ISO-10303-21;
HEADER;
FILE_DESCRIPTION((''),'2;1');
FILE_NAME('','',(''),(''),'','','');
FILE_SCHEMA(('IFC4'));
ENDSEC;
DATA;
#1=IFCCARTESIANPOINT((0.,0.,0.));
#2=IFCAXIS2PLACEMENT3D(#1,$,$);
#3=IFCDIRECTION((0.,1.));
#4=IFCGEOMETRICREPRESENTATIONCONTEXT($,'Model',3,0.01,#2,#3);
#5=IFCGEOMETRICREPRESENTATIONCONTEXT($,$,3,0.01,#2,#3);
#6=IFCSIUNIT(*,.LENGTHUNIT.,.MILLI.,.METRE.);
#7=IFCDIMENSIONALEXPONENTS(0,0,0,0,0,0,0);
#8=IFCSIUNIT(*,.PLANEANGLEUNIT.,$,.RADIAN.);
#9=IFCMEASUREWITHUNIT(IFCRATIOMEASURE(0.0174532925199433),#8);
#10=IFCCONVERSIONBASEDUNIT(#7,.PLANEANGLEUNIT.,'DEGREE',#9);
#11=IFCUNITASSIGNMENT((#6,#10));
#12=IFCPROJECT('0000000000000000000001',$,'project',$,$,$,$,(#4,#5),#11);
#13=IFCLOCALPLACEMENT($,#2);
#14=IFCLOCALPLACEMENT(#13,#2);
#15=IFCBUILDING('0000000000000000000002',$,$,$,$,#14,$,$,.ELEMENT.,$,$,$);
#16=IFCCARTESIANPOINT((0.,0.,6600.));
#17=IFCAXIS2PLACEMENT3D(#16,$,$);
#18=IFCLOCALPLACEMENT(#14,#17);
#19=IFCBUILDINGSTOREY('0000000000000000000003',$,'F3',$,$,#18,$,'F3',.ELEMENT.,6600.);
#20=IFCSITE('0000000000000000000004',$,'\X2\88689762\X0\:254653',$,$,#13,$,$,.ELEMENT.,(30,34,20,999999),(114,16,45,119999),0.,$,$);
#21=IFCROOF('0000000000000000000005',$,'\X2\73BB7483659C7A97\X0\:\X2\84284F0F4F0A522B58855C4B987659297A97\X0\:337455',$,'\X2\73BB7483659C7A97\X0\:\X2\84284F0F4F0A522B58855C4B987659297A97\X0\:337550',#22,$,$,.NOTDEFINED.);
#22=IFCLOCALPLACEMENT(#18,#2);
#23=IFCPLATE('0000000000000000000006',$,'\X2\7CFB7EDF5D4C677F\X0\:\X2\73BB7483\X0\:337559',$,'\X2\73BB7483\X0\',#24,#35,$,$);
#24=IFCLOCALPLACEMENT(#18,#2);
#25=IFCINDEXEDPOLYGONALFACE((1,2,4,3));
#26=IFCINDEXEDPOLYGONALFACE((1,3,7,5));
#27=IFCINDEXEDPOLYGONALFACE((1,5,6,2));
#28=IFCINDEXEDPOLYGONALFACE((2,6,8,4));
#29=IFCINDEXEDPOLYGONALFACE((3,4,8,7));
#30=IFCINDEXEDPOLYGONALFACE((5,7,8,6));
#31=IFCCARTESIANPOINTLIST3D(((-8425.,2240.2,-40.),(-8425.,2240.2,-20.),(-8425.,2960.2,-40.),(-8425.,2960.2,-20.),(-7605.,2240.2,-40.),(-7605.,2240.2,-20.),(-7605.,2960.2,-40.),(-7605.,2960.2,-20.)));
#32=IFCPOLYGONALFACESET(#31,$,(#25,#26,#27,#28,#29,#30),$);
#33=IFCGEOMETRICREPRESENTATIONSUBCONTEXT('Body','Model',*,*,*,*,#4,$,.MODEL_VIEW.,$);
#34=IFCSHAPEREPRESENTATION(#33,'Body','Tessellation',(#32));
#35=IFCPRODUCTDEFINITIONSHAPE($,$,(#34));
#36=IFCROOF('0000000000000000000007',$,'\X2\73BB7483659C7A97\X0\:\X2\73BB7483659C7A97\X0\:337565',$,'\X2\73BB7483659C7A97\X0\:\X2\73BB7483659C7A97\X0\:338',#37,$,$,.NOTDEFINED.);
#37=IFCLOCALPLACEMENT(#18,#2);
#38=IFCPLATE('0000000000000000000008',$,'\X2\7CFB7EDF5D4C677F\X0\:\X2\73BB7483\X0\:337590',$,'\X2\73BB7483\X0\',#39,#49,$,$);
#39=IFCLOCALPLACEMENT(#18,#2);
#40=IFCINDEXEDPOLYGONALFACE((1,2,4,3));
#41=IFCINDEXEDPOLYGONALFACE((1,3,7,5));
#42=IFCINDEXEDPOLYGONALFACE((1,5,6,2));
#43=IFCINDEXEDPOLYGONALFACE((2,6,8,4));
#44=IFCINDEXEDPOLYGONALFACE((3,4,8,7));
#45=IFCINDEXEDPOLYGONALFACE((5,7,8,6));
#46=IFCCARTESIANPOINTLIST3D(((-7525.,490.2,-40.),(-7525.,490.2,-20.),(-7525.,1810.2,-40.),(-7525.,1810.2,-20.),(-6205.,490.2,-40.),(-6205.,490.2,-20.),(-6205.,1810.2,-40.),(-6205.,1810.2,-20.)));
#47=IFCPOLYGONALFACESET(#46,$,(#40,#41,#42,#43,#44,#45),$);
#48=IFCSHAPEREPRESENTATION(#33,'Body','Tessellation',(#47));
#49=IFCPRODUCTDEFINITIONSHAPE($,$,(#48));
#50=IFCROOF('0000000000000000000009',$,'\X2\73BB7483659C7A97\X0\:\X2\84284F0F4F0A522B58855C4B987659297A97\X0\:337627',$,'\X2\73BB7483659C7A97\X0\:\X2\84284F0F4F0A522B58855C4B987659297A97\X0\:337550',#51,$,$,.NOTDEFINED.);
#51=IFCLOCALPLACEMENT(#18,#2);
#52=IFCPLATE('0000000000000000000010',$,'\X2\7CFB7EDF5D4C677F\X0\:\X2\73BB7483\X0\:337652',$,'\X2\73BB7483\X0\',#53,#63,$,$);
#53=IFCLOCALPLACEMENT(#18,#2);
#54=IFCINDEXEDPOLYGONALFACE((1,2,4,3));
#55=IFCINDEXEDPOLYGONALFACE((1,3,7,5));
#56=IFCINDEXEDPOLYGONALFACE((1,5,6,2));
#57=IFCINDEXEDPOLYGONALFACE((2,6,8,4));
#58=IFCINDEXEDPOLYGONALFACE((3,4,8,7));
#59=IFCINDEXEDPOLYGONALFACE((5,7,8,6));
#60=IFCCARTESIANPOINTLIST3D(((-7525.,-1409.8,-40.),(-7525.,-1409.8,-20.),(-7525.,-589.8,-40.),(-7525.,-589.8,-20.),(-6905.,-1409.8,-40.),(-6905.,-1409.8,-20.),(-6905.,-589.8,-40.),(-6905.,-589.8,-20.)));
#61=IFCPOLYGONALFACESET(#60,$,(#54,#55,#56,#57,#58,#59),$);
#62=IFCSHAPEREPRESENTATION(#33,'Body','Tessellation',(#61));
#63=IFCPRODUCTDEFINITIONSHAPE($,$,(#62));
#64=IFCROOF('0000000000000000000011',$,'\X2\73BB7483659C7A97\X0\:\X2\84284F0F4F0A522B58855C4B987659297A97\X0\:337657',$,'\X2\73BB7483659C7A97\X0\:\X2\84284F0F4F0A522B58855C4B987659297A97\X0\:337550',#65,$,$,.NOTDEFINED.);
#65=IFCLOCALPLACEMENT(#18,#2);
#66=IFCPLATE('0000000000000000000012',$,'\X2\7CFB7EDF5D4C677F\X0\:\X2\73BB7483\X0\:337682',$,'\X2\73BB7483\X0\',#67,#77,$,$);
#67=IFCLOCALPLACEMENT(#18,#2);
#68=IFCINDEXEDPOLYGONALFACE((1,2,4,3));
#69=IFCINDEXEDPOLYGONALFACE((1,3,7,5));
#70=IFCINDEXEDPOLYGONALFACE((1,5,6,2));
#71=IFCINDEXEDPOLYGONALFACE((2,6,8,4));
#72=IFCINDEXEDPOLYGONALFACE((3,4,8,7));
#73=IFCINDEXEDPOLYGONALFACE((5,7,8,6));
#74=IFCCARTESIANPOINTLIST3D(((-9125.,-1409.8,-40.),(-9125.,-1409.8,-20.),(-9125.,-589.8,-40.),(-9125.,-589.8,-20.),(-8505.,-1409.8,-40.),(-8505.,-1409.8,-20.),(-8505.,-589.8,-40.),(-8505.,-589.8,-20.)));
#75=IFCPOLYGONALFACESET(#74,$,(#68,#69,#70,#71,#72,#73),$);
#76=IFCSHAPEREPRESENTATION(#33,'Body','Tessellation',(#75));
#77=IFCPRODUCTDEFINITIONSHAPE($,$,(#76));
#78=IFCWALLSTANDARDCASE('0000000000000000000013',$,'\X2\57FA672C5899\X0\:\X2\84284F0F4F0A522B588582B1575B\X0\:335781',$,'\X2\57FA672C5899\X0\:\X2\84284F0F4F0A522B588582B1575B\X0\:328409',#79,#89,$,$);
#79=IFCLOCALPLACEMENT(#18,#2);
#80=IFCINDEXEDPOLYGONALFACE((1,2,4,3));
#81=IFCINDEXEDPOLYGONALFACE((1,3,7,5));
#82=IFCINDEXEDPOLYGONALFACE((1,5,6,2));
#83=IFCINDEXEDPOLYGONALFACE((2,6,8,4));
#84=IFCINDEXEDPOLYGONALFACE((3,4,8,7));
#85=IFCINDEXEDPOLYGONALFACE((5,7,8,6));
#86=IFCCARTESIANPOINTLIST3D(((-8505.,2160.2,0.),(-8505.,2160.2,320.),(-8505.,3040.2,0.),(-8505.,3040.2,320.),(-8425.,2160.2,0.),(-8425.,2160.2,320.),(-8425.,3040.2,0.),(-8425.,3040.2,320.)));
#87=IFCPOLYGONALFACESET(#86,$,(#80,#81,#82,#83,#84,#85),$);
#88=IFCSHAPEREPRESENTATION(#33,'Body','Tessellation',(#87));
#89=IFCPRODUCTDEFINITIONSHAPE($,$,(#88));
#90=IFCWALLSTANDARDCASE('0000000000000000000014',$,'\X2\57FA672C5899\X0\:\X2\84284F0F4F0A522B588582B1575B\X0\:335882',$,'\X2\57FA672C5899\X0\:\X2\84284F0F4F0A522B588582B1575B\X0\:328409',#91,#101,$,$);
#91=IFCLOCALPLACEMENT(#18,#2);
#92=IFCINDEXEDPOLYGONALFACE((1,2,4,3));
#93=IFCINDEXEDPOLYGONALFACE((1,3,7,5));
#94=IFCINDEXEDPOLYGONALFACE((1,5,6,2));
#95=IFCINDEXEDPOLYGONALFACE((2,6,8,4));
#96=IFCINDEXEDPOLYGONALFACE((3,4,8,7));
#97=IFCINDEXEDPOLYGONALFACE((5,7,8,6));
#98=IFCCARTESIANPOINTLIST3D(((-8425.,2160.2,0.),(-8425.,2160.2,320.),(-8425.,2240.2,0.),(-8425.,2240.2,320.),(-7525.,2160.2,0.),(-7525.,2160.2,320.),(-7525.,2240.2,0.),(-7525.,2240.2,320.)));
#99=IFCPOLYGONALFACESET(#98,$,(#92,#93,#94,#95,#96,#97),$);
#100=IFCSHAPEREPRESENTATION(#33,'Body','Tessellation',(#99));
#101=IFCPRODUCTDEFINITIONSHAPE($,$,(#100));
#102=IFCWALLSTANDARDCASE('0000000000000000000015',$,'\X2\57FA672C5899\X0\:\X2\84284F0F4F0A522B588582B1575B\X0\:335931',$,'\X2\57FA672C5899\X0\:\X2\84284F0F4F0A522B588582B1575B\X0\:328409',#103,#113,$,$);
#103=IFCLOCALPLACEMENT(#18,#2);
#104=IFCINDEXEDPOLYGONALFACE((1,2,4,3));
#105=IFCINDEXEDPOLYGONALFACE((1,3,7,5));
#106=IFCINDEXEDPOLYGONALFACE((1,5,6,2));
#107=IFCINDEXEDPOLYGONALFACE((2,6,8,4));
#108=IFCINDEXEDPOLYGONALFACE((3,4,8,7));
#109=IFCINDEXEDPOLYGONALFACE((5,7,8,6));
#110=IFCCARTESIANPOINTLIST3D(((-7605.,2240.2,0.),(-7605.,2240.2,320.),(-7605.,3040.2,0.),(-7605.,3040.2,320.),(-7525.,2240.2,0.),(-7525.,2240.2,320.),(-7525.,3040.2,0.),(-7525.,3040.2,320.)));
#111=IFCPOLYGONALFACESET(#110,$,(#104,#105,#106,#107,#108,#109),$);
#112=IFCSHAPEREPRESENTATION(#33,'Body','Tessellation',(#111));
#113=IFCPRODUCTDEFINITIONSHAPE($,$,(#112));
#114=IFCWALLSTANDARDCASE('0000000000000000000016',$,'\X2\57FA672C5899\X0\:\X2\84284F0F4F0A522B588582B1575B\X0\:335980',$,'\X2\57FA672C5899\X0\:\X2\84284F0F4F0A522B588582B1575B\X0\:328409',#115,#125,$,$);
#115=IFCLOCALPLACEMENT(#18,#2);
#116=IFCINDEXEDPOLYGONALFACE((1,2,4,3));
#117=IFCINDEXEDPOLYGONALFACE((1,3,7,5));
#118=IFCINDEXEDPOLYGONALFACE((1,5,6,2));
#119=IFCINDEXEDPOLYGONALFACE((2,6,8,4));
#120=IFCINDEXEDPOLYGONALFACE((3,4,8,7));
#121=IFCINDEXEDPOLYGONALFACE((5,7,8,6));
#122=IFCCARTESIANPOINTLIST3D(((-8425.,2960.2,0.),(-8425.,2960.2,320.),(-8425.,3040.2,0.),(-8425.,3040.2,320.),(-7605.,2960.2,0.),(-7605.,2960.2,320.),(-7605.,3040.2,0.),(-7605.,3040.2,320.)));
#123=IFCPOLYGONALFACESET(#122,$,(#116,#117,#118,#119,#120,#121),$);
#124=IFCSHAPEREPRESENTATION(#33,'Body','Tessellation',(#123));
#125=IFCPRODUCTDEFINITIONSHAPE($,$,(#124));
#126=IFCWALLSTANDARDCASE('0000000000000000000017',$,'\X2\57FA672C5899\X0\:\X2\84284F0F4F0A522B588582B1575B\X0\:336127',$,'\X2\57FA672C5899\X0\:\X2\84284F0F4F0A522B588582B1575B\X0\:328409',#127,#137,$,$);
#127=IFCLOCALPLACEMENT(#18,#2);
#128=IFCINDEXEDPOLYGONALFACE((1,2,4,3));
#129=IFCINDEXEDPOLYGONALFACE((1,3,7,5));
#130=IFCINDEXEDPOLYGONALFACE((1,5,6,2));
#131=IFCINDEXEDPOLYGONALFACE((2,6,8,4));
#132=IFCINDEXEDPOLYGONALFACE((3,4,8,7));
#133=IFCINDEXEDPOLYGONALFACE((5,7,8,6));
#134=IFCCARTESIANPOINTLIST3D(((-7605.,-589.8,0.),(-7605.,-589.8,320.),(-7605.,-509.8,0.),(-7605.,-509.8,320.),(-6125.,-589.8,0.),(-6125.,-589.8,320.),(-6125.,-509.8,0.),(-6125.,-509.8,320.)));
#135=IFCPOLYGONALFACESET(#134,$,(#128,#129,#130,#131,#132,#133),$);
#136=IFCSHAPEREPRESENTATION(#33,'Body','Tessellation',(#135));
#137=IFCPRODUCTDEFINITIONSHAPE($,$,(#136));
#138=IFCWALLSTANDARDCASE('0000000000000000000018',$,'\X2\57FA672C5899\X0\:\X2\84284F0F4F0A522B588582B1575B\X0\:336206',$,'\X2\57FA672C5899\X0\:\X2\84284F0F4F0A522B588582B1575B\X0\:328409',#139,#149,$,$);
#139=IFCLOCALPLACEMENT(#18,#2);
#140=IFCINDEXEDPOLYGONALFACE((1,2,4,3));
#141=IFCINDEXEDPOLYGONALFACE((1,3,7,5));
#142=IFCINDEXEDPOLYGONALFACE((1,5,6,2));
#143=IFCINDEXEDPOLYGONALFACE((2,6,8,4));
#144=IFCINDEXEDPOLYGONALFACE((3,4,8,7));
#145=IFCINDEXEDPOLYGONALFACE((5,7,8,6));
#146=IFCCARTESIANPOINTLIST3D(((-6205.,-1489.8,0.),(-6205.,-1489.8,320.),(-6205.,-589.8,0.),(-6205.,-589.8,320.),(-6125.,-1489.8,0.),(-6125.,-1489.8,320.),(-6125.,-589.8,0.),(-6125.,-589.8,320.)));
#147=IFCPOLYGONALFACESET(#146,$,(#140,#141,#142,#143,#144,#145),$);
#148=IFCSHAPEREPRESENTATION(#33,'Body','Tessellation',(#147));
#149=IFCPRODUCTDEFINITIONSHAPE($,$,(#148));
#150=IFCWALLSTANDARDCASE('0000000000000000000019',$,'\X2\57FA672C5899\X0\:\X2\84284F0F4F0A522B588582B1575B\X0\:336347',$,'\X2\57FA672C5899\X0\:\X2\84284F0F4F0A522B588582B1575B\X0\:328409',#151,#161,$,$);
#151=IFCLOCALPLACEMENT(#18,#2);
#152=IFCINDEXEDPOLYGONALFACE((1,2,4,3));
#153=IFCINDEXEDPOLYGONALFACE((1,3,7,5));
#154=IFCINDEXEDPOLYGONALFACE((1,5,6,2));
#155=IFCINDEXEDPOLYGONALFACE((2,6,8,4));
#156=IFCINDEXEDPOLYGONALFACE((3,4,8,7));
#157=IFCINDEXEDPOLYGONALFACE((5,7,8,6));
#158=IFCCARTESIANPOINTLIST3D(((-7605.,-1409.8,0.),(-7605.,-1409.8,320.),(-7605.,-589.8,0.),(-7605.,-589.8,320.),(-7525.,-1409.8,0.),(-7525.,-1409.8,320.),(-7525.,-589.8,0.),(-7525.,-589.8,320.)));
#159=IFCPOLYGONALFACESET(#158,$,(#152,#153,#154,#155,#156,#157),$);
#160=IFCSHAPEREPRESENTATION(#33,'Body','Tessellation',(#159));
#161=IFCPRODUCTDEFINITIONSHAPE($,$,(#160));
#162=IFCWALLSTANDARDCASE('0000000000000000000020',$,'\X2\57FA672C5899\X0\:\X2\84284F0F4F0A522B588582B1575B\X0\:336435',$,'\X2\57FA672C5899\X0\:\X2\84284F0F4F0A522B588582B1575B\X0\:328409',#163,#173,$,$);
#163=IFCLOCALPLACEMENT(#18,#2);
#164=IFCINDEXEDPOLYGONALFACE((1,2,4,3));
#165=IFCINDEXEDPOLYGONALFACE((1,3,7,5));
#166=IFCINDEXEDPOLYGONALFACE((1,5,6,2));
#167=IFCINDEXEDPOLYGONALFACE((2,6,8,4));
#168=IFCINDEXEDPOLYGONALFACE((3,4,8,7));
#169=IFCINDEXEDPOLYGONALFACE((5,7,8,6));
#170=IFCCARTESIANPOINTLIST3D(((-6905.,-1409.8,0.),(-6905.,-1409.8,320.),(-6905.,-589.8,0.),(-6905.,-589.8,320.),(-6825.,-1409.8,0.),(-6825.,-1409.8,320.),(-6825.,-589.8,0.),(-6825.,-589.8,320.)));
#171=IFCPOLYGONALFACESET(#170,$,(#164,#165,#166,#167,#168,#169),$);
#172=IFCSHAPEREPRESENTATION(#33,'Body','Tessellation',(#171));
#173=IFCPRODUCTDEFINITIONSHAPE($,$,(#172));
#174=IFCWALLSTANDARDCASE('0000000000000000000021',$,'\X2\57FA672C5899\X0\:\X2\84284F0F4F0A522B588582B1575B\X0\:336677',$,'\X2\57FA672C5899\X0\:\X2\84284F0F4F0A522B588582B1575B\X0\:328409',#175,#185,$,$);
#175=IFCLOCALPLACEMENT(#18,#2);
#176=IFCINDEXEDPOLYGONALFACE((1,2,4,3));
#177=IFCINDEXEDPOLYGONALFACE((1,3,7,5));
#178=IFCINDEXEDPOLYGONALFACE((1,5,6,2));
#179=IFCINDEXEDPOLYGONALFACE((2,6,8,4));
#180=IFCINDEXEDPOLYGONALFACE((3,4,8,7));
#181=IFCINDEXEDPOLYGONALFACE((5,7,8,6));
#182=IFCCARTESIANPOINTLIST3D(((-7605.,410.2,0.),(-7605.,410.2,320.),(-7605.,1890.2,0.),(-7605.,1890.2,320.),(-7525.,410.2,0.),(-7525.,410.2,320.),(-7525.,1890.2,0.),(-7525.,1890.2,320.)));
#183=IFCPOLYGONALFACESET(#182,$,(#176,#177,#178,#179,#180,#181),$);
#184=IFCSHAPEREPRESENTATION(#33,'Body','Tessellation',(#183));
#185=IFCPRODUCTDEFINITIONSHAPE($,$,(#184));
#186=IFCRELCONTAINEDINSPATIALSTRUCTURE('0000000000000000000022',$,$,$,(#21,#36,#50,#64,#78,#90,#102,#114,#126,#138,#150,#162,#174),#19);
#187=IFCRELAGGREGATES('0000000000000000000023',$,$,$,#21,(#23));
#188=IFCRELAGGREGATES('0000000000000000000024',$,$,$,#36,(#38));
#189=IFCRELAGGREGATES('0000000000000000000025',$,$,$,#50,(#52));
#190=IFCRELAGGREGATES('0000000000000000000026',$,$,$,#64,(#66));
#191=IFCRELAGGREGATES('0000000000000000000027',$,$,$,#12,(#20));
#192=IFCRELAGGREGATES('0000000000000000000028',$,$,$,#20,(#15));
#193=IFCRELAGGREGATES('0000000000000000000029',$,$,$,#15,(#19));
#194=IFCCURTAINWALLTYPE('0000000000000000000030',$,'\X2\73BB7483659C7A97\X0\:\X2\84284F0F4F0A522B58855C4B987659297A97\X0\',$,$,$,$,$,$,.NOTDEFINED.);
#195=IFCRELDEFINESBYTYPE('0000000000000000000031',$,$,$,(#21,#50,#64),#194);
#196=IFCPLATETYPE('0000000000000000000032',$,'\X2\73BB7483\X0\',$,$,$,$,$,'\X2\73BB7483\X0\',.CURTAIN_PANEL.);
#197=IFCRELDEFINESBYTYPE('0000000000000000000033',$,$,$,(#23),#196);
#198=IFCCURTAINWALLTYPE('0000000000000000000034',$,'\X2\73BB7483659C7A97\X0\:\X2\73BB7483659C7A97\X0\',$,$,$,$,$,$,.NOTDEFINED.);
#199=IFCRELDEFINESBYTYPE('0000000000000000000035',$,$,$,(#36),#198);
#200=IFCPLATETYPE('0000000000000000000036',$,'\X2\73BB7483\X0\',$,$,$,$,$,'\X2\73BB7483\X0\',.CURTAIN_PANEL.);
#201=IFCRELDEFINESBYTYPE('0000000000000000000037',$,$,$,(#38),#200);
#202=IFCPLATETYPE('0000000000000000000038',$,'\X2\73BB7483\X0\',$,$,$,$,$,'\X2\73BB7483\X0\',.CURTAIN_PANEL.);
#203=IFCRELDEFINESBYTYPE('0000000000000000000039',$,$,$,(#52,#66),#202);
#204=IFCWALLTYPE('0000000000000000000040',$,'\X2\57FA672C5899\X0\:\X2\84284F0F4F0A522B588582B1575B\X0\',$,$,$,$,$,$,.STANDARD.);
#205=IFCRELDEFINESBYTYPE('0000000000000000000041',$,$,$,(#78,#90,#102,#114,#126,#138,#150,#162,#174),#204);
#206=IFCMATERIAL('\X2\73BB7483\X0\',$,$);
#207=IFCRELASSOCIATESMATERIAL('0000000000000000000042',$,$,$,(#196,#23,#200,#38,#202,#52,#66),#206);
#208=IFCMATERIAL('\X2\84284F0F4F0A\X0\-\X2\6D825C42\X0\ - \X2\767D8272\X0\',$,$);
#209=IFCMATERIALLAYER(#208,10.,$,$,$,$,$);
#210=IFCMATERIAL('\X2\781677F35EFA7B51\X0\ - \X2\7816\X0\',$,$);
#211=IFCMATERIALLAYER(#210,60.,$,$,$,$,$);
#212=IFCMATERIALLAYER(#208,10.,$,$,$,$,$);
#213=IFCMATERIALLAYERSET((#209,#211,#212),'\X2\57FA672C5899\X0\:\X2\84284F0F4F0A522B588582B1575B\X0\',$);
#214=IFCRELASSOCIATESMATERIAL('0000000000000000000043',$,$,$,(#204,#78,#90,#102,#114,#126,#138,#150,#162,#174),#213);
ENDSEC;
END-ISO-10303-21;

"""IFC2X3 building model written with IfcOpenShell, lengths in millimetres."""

from ifc_helpers import new_model, entity, si_unit, converted_unit, direction, frame, frame_2d, origin, place, context, subcontext, project, spatial, rectangle, extrude, source, transform, mapped, material, layer, layer_set, layer_usage, type_object, type_shapes, element, aggregate, save


model = new_model("IFC2X3")

# Units and contexts
model_context = context("Model", 3, precision=0.01, world=origin(), true_north=direction((0.0, 1.0)))
context_of_model = context(None, 3, precision=0.01, world=origin(), true_north=direction((0.0, 1.0)))
body_context = subcontext(model_context, "Body", "Model", "MODEL_VIEW")
ifc_project = project(units=[si_unit("LENGTHUNIT", "METRE", prefix="MILLI"), converted_unit("PLANEANGLEUNIT", "DEGREE", entity("IfcRatioMeasure", 0.0174532925199433), si_unit("PLANEANGLEUNIT", "RADIAN"), dimensions=[0, 0, 0, 0, 0, 0, 0])], contexts=[model_context, context_of_model])

# Site, building, storey
site_placement = place(None, origin())
site = spatial("IfcSite", under=ifc_project, at=site_placement, Name="表面:254653", CompositionType="ELEMENT", RefLatitude=(30, 34, 20, 999999), RefLongitude=(114, 16, 45, 119999), RefElevation=0.0)
building_placement = place(site_placement, origin())
building = spatial("IfcBuilding", under=site, at=building_placement, CompositionType="ELEMENT")
storey_placement = place(building_placement, frame((0.0, 0.0, 6600.0)))
storey = spatial("IfcBuildingStorey", under=building, at=storey_placement, Name="F3", LongName="F3", CompositionType="ELEMENT", Elevation=6600.0)

# Roofs, plates
curtain_wall_type_1 = type_object("IfcCurtainWallType", Name="玻璃斜窗:萨伏伊别墅屋顶天窗", PredefinedType="NOTDEFINED")
roof_1_placement = place(storey_placement, frame((0.0, 0.0, -6600.0)))
roof_1 = element("IfcRoof", 1, at=roof_1_placement, inside=storey, type_object=curtain_wall_type_1, Name="玻璃斜窗:萨伏伊别墅屋顶天窗:337455", ObjectType="玻璃斜窗:萨伏伊别墅屋顶天窗:337550", ShapeType="NOTDEFINED")
ifc_material_1 = material(Name="玻璃")
plate_type_1 = type_object("IfcPlateType", Name="玻璃", ElementType="玻璃", PredefinedType="CURTAIN_PANEL", material=ifc_material_1)
shared_shape_1 = source(origin(), body_context, "Body", "SweptSolid", [
    extrude(rectangle(XDim=20.0, YDim=820.0, at=frame_2d((0.0, 0.0), x_axis=(1.0, 0.0))), frame((0.0, 30.0, 0.0), z_axis=(0.0, 0.0, 1.0), x_axis=(0.0, 1.0, 0.0)), (0.0, 0.0, 1.0), 720.0),
])
type_shapes(plate_type_1, [shared_shape_1])
plate_1_placement = place(roof_1_placement, frame((-8015.0, 2240.2, 6600.0), z_axis=(0.0, 1.0, 0.0), x_axis=(1.0, 0.0, 0.0)))
plate_1 = element("IfcPlate", 2, at=plate_1_placement, type_object=plate_type_1, material=ifc_material_1, Name="系统嵌板:玻璃:337559", ObjectType="玻璃", context=body_context, shape_type="MappedRepresentation", body=[
    mapped(shared_shape_1, transform((0.0, 0.0, 0.0), scale=1.0)),
])
aggregate(roof_1, [plate_1])
curtain_wall_type_2 = type_object("IfcCurtainWallType", Name="玻璃斜窗:玻璃斜窗", PredefinedType="NOTDEFINED")
roof_2_placement = place(storey_placement, frame((0.0, 0.0, -6600.0)))
roof_2 = element("IfcRoof", 3, at=roof_2_placement, inside=storey, type_object=curtain_wall_type_2, Name="玻璃斜窗:玻璃斜窗:337565", ObjectType="玻璃斜窗:玻璃斜窗:338", ShapeType="NOTDEFINED")
plate_type_2 = type_object("IfcPlateType", Name="玻璃", ElementType="玻璃", PredefinedType="CURTAIN_PANEL", material=ifc_material_1)
shared_shape_2 = source(origin(), body_context, "Body", "SweptSolid", [
    extrude(rectangle(XDim=20.0, YDim=1320.0, at=frame_2d((0.0, 0.0), x_axis=(1.0, 0.0))), frame((0.0, 30.0, 0.0), z_axis=(0.0, 0.0, 1.0), x_axis=(0.0, 1.0, 0.0)), (0.0, 0.0, 1.0), 1320.0),
])
type_shapes(plate_type_2, [shared_shape_2])
plate_2_placement = place(roof_2_placement, frame((-6865.0, 490.2, 6600.0), z_axis=(0.0, 1.0, 0.0), x_axis=(1.0, 0.0, 0.0)))
plate_2 = element("IfcPlate", 4, at=plate_2_placement, type_object=plate_type_2, material=ifc_material_1, Name="系统嵌板:玻璃:337590", ObjectType="玻璃", context=body_context, shape_type="MappedRepresentation", body=[
    mapped(shared_shape_2, transform((0.0, 0.0, 0.0), scale=1.0)),
])
aggregate(roof_2, [plate_2])
roof_3_placement = place(storey_placement, frame((0.0, 0.0, -6600.0)))
roof_3 = element("IfcRoof", 5, at=roof_3_placement, inside=storey, type_object=curtain_wall_type_1, Name="玻璃斜窗:萨伏伊别墅屋顶天窗:337627", ObjectType="玻璃斜窗:萨伏伊别墅屋顶天窗:337550", ShapeType="NOTDEFINED")
plate_type_3 = type_object("IfcPlateType", Name="玻璃", ElementType="玻璃", PredefinedType="CURTAIN_PANEL", material=ifc_material_1)
shared_shape_3 = source(origin(), body_context, "Body", "SweptSolid", [
    extrude(rectangle(XDim=20.0, YDim=620.0, at=frame_2d((0.0, 0.0), x_axis=(1.0, 0.0))), frame((0.0, 30.0, 0.0), z_axis=(0.0, 0.0, 1.0), x_axis=(0.0, 1.0, 0.0)), (0.0, 0.0, 1.0), 820.0),
])
type_shapes(plate_type_3, [shared_shape_3])
plate_3_placement = place(roof_3_placement, frame((-7215.0, -1409.8, 6600.0), z_axis=(0.0, 1.0, 0.0), x_axis=(1.0, 0.0, 0.0)))
plate_3 = element("IfcPlate", 6, at=plate_3_placement, type_object=plate_type_3, material=ifc_material_1, Name="系统嵌板:玻璃:337652", ObjectType="玻璃", context=body_context, shape_type="MappedRepresentation", body=[
    mapped(shared_shape_3, transform((0.0, 0.0, 0.0), scale=1.0)),
])
aggregate(roof_3, [plate_3])
roof_4_placement = place(storey_placement, frame((0.0, 0.0, -6600.0)))
roof_4 = element("IfcRoof", 7, at=roof_4_placement, inside=storey, type_object=curtain_wall_type_1, Name="玻璃斜窗:萨伏伊别墅屋顶天窗:337657", ObjectType="玻璃斜窗:萨伏伊别墅屋顶天窗:337550", ShapeType="NOTDEFINED")
plate_4_placement = place(roof_4_placement, frame((-8815.0, -1409.8, 6600.0), z_axis=(0.0, 1.0, 0.0), x_axis=(1.0, 0.0, 0.0)))
plate_4 = element("IfcPlate", 8, at=plate_4_placement, type_object=plate_type_3, material=ifc_material_1, Name="系统嵌板:玻璃:337682", ObjectType="玻璃", context=body_context, shape_type="MappedRepresentation", body=[
    mapped(shared_shape_3, transform((0.0, 0.0, 0.0), scale=1.0)),
])
aggregate(roof_4, [plate_4])

# Walls
ifc_material_2 = material(Name="萨伏伊-涂层 - 白色")
ifc_layer_1 = layer(ifc_material_2, 10.0)
ifc_material_3 = material(Name="砖石建筑 - 砖")
ifc_layer_2 = layer(ifc_material_3, 60.0)
ifc_layer_3 = layer(ifc_material_2, 10.0)
ifc_layer_set = layer_set([ifc_layer_1, ifc_layer_2, ifc_layer_3], Name="基本墙:萨伏伊别墅花坛")
ifc_layer_usage_1 = layer_usage(ifc_layer_set, "AXIS2", "NEGATIVE", 40.0)
wall_type = type_object("IfcWallType", Name="基本墙:萨伏伊别墅花坛", PredefinedType="STANDARD", material=ifc_layer_set)
wall_1_placement = place(storey_placement, frame((-8465.0, 3040.2, 0.0), z_axis=(0.0, 0.0, 1.0), x_axis=(0.0, -1.0, 0.0)))
element("IfcWallStandardCase", 9, at=wall_1_placement, inside=storey, type_object=wall_type, material=ifc_layer_usage_1, Name="基本墙:萨伏伊别墅花坛:335781", ObjectType="基本墙:萨伏伊别墅花坛:328409", context=body_context, shape_type="SweptSolid", body=[
    extrude(rectangle(XDim=880.0, YDim=80.0, at=frame_2d((440.0, 0.0), x_axis=(-1.0, 0.0))), origin(), (0.0, 0.0, 1.0), 320.0),
])
ifc_layer_usage_2 = layer_usage(ifc_layer_set, "AXIS2", "NEGATIVE", 40.0)
wall_2_placement = place(storey_placement, frame((-8425.0, 2200.2, 0.0)))
element("IfcWallStandardCase", 10, at=wall_2_placement, inside=storey, type_object=wall_type, material=ifc_layer_usage_2, Name="基本墙:萨伏伊别墅花坛:335882", ObjectType="基本墙:萨伏伊别墅花坛:328409", context=body_context, shape_type="SweptSolid", body=[
    extrude(rectangle(XDim=900.0, YDim=80.0, at=frame_2d((450.0, 0.0), x_axis=(-1.0, 0.0))), origin(), (0.0, 0.0, 1.0), 320.0),
])
ifc_layer_usage_3 = layer_usage(ifc_layer_set, "AXIS2", "NEGATIVE", 40.0)
wall_3_placement = place(storey_placement, frame((-7565.0, 2240.2, 0.0), z_axis=(0.0, 0.0, 1.0), x_axis=(0.0, 1.0, 0.0)))
element("IfcWallStandardCase", 11, at=wall_3_placement, inside=storey, type_object=wall_type, material=ifc_layer_usage_3, Name="基本墙:萨伏伊别墅花坛:335931", ObjectType="基本墙:萨伏伊别墅花坛:328409", context=body_context, shape_type="SweptSolid", body=[
    extrude(rectangle(XDim=800.0, YDim=80.0, at=frame_2d((400.0, 0.0), x_axis=(-1.0, 0.0))), origin(), (0.0, 0.0, 1.0), 320.0),
])
ifc_layer_usage_4 = layer_usage(ifc_layer_set, "AXIS2", "NEGATIVE", 40.0)
wall_4_placement = place(storey_placement, frame((-7605.0, 3000.2, 0.0), z_axis=(0.0, 0.0, 1.0), x_axis=(-1.0, 0.0, 0.0)))
element("IfcWallStandardCase", 12, at=wall_4_placement, inside=storey, type_object=wall_type, material=ifc_layer_usage_4, Name="基本墙:萨伏伊别墅花坛:335980", ObjectType="基本墙:萨伏伊别墅花坛:328409", context=body_context, shape_type="SweptSolid", body=[
    extrude(rectangle(XDim=820.0, YDim=80.0, at=frame_2d((410.0, 0.0), x_axis=(-1.0, 0.0))), origin(), (0.0, 0.0, 1.0), 320.0),
])
ifc_layer_usage_5 = layer_usage(ifc_layer_set, "AXIS2", "NEGATIVE", 40.0)
wall_5_placement = place(storey_placement, frame((-7605.0, -549.8, 0.0)))
element("IfcWallStandardCase", 13, at=wall_5_placement, inside=storey, type_object=wall_type, material=ifc_layer_usage_5, Name="基本墙:萨伏伊别墅花坛:336127", ObjectType="基本墙:萨伏伊别墅花坛:328409", context=body_context, shape_type="SweptSolid", body=[
    extrude(rectangle(XDim=1480.0, YDim=80.0, at=frame_2d((740.0, 0.0), x_axis=(-1.0, 0.0))), origin(), (0.0, 0.0, 1.0), 320.0),
])
ifc_layer_usage_6 = layer_usage(ifc_layer_set, "AXIS2", "NEGATIVE", 40.0)
wall_6_placement = place(storey_placement, frame((-6165.0, -589.8, 0.0), z_axis=(0.0, 0.0, 1.0), x_axis=(0.0, -1.0, 0.0)))
element("IfcWallStandardCase", 14, at=wall_6_placement, inside=storey, type_object=wall_type, material=ifc_layer_usage_6, Name="基本墙:萨伏伊别墅花坛:336206", ObjectType="基本墙:萨伏伊别墅花坛:328409", context=body_context, shape_type="SweptSolid", body=[
    extrude(rectangle(XDim=900.0, YDim=80.0, at=frame_2d((450.0, 0.0), x_axis=(-1.0, 0.0))), origin(), (0.0, 0.0, 1.0), 320.0),
])
ifc_layer_usage_7 = layer_usage(ifc_layer_set, "AXIS2", "NEGATIVE", 40.0)
wall_7_placement = place(storey_placement, frame((-7565.0, -1409.8, 0.0), z_axis=(0.0, 0.0, 1.0), x_axis=(0.0, 1.0, 0.0)))
element("IfcWallStandardCase", 15, at=wall_7_placement, inside=storey, type_object=wall_type, material=ifc_layer_usage_7, Name="基本墙:萨伏伊别墅花坛:336347", ObjectType="基本墙:萨伏伊别墅花坛:328409", context=body_context, shape_type="SweptSolid", body=[
    extrude(rectangle(XDim=820.0, YDim=80.0, at=frame_2d((410.0, 0.0), x_axis=(-1.0, 0.0))), origin(), (0.0, 0.0, 1.0), 320.0),
])
ifc_layer_usage_8 = layer_usage(ifc_layer_set, "AXIS2", "NEGATIVE", 40.0)
wall_8_placement = place(storey_placement, frame((-6865.0, -589.8, 0.0), z_axis=(0.0, 0.0, 1.0), x_axis=(0.0, -1.0, 0.0)))
element("IfcWallStandardCase", 16, at=wall_8_placement, inside=storey, type_object=wall_type, material=ifc_layer_usage_8, Name="基本墙:萨伏伊别墅花坛:336435", ObjectType="基本墙:萨伏伊别墅花坛:328409", context=body_context, shape_type="SweptSolid", body=[
    extrude(rectangle(XDim=820.0, YDim=80.0, at=frame_2d((410.0, 0.0), x_axis=(-1.0, 0.0))), origin(), (0.0, 0.0, 1.0), 320.0),
])
ifc_layer_usage_9 = layer_usage(ifc_layer_set, "AXIS2", "NEGATIVE", 40.0)
wall_9_placement = place(storey_placement, frame((-7565.0, 410.2, 0.0), z_axis=(0.0, 0.0, 1.0), x_axis=(0.0, 1.0, 0.0)))
element("IfcWallStandardCase", 17, at=wall_9_placement, inside=storey, type_object=wall_type, material=ifc_layer_usage_9, Name="基本墙:萨伏伊别墅花坛:336677", ObjectType="基本墙:萨伏伊别墅花坛:328409", context=body_context, shape_type="SweptSolid", body=[
    extrude(rectangle(XDim=1480.0, YDim=80.0, at=frame_2d((740.0, 0.0), x_axis=(-1.0, 0.0))), origin(), (0.0, 0.0, 1.0), 320.0),
])

save(model, "model.ifc")
